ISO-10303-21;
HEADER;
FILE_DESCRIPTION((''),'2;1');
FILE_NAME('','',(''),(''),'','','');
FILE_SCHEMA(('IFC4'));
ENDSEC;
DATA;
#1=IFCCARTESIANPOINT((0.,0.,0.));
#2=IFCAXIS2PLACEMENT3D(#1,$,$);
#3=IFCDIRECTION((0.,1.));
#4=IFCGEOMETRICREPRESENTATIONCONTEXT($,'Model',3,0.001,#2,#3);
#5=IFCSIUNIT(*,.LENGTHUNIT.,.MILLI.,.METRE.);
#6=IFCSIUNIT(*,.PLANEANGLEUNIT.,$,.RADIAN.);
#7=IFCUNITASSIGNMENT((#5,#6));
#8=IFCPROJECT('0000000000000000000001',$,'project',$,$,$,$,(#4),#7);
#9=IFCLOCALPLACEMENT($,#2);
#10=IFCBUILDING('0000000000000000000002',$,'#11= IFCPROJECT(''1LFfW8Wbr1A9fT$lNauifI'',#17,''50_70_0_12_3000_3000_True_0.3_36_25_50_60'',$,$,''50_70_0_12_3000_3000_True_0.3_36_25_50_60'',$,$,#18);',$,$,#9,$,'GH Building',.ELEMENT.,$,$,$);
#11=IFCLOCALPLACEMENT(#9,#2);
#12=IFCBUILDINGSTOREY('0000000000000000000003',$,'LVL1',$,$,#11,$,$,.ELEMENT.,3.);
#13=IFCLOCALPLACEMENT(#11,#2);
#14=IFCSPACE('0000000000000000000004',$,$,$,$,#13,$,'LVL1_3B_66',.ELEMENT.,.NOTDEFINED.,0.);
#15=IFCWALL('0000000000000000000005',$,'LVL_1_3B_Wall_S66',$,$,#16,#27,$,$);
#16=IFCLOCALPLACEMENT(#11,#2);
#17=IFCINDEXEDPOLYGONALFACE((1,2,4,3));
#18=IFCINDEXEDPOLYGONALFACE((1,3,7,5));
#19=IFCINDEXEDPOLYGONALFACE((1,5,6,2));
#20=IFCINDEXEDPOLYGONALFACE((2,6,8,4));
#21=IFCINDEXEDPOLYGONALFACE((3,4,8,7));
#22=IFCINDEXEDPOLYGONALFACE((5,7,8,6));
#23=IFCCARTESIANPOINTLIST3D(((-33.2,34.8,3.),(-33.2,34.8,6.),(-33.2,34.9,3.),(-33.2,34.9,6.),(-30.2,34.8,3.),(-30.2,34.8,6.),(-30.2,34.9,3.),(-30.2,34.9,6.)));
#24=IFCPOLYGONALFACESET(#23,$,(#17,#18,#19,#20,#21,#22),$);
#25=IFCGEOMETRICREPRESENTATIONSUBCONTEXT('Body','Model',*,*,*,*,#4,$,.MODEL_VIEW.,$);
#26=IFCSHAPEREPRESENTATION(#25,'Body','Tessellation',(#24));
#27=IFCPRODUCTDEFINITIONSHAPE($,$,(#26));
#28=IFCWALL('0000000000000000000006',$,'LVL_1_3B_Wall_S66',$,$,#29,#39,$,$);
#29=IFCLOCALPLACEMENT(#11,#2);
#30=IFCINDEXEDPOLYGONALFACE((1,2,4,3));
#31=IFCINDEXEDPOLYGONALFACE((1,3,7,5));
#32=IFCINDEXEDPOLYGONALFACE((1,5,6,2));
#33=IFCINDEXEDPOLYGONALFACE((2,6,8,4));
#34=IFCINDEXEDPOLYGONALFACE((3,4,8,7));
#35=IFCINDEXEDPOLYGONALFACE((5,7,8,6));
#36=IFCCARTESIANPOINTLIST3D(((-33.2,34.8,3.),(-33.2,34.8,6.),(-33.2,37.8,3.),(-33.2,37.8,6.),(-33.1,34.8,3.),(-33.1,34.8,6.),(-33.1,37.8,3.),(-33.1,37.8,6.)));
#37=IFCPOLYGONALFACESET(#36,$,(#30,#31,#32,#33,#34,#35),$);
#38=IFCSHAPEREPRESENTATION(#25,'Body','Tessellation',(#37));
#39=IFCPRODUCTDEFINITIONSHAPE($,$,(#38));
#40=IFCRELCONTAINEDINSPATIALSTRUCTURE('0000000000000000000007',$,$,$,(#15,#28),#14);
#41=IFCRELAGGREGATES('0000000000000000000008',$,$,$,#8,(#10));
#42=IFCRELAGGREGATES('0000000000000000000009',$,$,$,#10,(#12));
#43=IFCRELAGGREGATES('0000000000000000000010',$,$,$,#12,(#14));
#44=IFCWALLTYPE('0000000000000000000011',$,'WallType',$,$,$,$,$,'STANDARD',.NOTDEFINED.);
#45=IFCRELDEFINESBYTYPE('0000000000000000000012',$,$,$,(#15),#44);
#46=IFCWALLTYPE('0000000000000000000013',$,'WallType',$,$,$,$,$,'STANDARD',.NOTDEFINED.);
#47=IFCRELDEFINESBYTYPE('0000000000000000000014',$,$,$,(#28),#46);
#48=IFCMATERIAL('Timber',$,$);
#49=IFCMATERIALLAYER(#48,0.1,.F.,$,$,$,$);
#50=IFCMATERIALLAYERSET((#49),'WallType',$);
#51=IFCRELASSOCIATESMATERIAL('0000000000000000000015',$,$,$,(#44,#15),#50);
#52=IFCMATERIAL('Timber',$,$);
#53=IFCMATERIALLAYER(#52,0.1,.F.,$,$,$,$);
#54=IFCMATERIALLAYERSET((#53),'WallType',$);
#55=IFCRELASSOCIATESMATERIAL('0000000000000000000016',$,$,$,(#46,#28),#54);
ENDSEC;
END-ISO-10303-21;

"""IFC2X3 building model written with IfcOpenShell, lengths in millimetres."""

from ifc_helpers import new_model, si_unit, direction, frame, frame_2d, origin, place, context, subcontext, project, spatial, rectangle, extrude, material, layer, layer_set, layer_usage, type_object, element, save


model = new_model("IFC2X3")

# Units and contexts
model_context = context("Model", 3, precision=0.001, world=origin(), true_north=direction((0.0, 1.0)))
body_context = subcontext(model_context, "Body", "Model", "MODEL_VIEW")
ifc_project = project(units=[si_unit("LENGTHUNIT", "METRE", prefix="MILLI"), si_unit("PLANEANGLEUNIT", "RADIAN")], contexts=[model_context])

# Building, storey
building_placement = place(None, origin())
building = spatial("IfcBuilding", under=ifc_project, at=building_placement, Name="#11= IFCPROJECT('1LFfW8Wbr1A9fT$lNauifI',#17,'50_70_0_12_3000_3000_True_0.3_36_25_50_60',$,$,'50_70_0_12_3000_3000_True_0.3_36_25_50_60',$,$,#18);", LongName="GH Building", CompositionType="ELEMENT")
storey_placement = place(building_placement, origin())
storey = spatial("IfcBuildingStorey", under=building, at=storey_placement, Name="LVL1", CompositionType="ELEMENT", Elevation=3.0)

# Shared definitions
space_1_placement = place(storey_placement, origin())
space_1 = spatial("IfcSpace", under=storey, at=space_1_placement, LongName="LVL1_3B_66", CompositionType="ELEMENT", InteriorOrExteriorSpace="NOTDEFINED", ElevationWithFlooring=0.0)

# Walls
ifc_material_1 = material(Name="Timber")
ifc_layer_1 = layer(ifc_material_1, 0.1, ventilated=False)
ifc_layer_set_1 = layer_set([ifc_layer_1], Name="WallType")
ifc_layer_usage_1 = layer_usage(ifc_layer_set_1, "AXIS2", "NEGATIVE", 0.0)
wall_type_1 = type_object("IfcWallType", Name="WallType", ElementType="STANDARD", PredefinedType="NOTDEFINED", material=ifc_layer_set_1)
wall_1_placement = place(space_1_placement, frame((-30.2, 34.8, 3.0), z_axis=(0.0, 0.0, 1.0), x_axis=(-1.0, 0.0, 0.0)))
element("IfcWall", 1, at=wall_1_placement, inside=space_1, type_object=wall_type_1, material=ifc_layer_usage_1, Name="LVL_1_3B_Wall_S66", context=body_context, shape_type="SweptSolid", body=[
    extrude(rectangle(XDim=3.0, YDim=0.1, at=frame_2d((1.5, -0.1))), origin(), (0.0, 0.0, 1.0), 3.0),
])
ifc_material_2 = material(Name="Timber")
ifc_layer_2 = layer(ifc_material_2, 0.1, ventilated=False)
ifc_layer_set_2 = layer_set([ifc_layer_2], Name="WallType")
ifc_layer_usage_2 = layer_usage(ifc_layer_set_2, "AXIS2", "NEGATIVE", 0.0)
wall_type_2 = type_object("IfcWallType", Name="WallType", ElementType="STANDARD", PredefinedType="NOTDEFINED", material=ifc_layer_set_2)
wall_2_placement = place(space_1_placement, frame((-33.2, 34.8, 3.0), z_axis=(0.0, 0.0, 1.0), x_axis=(0.0, 1.0, 0.0)))
element("IfcWall", 2, at=wall_2_placement, inside=space_1, type_object=wall_type_2, material=ifc_layer_usage_2, Name="LVL_1_3B_Wall_S66", context=body_context, shape_type="SweptSolid", body=[
    extrude(rectangle(XDim=3.0, YDim=0.1, at=frame_2d((1.5, -0.1))), origin(), (0.0, 0.0, 1.0), 3.0),
])

save(model, "model.ifc")
